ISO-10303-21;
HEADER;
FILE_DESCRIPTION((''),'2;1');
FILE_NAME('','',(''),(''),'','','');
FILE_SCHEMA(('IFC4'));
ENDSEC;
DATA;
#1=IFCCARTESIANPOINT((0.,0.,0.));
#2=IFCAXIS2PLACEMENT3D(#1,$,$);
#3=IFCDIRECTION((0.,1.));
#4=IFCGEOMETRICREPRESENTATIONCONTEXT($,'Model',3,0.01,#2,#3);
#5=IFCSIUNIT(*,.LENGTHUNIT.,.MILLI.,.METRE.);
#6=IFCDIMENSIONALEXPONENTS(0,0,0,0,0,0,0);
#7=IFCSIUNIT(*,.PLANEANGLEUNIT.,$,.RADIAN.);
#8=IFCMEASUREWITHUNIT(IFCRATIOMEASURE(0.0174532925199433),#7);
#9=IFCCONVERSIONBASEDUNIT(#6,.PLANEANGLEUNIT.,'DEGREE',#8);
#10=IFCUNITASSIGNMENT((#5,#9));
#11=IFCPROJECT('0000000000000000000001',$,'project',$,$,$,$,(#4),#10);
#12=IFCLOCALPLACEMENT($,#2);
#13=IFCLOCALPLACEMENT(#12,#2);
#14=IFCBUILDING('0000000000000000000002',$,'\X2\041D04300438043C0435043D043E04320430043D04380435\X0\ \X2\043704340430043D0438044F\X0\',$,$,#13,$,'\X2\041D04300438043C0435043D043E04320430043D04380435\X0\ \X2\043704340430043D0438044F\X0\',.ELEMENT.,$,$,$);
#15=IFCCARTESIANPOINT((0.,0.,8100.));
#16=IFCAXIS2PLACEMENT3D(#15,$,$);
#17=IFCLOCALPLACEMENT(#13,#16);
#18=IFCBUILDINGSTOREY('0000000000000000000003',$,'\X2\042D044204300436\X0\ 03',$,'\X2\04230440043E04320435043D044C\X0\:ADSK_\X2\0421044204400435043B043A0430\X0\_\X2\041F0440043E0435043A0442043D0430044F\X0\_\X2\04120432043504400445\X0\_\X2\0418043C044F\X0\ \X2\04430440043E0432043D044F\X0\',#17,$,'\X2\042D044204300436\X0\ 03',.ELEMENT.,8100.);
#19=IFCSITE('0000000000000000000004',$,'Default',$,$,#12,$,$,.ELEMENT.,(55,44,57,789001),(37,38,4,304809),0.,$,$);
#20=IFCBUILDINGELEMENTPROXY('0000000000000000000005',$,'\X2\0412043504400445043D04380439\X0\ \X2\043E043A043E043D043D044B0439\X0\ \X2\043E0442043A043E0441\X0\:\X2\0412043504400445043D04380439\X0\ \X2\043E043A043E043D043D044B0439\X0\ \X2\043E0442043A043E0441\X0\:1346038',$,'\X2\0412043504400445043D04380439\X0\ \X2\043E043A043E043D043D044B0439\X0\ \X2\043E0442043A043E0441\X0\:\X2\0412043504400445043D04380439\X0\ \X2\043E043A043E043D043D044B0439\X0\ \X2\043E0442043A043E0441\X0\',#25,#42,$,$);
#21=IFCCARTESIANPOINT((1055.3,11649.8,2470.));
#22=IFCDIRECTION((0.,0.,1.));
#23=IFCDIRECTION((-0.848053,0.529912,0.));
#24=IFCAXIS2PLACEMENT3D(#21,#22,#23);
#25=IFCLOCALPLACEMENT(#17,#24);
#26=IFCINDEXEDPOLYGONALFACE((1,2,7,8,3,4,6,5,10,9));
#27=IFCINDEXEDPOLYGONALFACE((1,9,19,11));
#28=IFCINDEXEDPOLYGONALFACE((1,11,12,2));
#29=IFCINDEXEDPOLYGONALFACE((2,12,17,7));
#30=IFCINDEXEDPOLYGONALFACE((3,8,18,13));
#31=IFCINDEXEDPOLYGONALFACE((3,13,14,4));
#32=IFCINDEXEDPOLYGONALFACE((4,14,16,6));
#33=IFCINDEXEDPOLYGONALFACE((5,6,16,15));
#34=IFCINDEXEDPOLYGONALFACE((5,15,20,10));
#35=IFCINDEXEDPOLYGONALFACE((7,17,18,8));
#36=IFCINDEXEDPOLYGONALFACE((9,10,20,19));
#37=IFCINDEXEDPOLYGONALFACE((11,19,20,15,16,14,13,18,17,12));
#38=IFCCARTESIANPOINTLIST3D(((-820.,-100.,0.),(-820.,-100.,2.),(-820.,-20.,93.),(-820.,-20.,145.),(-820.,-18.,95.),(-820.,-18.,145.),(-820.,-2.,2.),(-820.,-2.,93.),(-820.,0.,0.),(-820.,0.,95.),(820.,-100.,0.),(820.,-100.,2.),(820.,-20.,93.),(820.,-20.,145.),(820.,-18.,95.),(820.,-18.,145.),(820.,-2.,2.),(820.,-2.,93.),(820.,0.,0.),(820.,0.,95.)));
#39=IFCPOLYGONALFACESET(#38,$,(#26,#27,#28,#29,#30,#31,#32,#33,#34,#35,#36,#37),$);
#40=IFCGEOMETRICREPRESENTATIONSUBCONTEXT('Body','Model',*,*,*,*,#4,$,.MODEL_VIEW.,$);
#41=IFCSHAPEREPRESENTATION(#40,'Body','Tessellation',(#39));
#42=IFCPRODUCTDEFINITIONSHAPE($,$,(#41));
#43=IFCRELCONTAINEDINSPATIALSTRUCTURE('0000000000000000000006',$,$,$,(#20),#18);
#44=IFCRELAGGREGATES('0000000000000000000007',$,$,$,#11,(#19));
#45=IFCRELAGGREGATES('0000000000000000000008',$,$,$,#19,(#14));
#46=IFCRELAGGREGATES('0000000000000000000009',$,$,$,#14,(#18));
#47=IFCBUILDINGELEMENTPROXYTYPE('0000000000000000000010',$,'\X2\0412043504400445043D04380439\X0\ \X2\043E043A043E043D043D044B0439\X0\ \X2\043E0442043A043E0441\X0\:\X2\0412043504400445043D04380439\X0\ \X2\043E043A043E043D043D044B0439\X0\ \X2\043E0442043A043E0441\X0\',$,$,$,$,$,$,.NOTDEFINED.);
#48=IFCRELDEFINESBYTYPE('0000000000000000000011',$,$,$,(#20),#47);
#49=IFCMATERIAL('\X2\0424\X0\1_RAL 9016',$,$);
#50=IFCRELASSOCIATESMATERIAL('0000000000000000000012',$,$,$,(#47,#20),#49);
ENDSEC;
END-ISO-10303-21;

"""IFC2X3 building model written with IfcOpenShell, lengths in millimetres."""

from ifc_helpers import new_model, entity, si_unit, converted_unit, direction, frame, origin, place, context, subcontext, project, spatial, polyline, outline, extrude, source, transform, mapped, material, type_object, type_shapes, element, save


model = new_model("IFC2X3")

# Units and contexts
model_context = context("Model", 3, precision=0.01, world=origin(), true_north=direction((0.0, 1.0)))
body_context = subcontext(model_context, "Body", "Model", "MODEL_VIEW")
ifc_project = project(units=[si_unit("LENGTHUNIT", "METRE", prefix="MILLI"), converted_unit("PLANEANGLEUNIT", "DEGREE", entity("IfcRatioMeasure", 0.0174532925199433), si_unit("PLANEANGLEUNIT", "RADIAN"), dimensions=[0, 0, 0, 0, 0, 0, 0])], contexts=[model_context])

# Site, building, storey
site_placement = place(None, origin())
site = spatial("IfcSite", under=ifc_project, at=site_placement, Name="Default", CompositionType="ELEMENT", RefLatitude=(55, 44, 57, 789001), RefLongitude=(37, 38, 4, 304809), RefElevation=0.0)
building_placement = place(site_placement, origin())
building = spatial("IfcBuilding", under=site, at=building_placement, Name="Наименование здания", LongName="Наименование здания", CompositionType="ELEMENT")
storey_placement = place(building_placement, frame((0.0, 0.0, 8100.0)))
storey = spatial("IfcBuildingStorey", under=building, at=storey_placement, Name="Этаж 03", ObjectType="Уровень:ADSK_Стрелка_Проектная_Вверх_Имя уровня", LongName="Этаж 03", CompositionType="ELEMENT", Elevation=8100.0)

# Building element proxy
ifc_material_1 = material(Name="Ф1_RAL 9016")
building_element_proxy_type_1 = type_object("IfcBuildingElementProxyType", Name="Верхний оконный откос:Верхний оконный откос", PredefinedType="NOTDEFINED", material=ifc_material_1)
shared_shape_1 = source(origin(), body_context, "Body", "SweptSolid", [
    extrude(outline(polyline([(28.0, -10.0), (78.0, -10.0), (78.0, -8.0), (26.0, -8.0), (26.0, -26.0), (-65.0, -26.0), (-65.0, 72.0), (-67.0, 72.0), (-67.0, -28.0), (28.0, -28.0), (28.0, -10.0)])), frame((-820.0, -28.0, 67.0), z_axis=(1.0, 0.0, 0.0), x_axis=(0.0, 0.0, 1.0)), (0.0, 0.0, 1.0), 1640.0),
])
type_shapes(building_element_proxy_type_1, [shared_shape_1])
proxy_1_placement = place(storey_placement, frame((1055.3, 11649.8, 2470.0), z_axis=(0.0, 0.0, 1.0), x_axis=(-0.848053, 0.529912, 0.0)))
element("IfcBuildingElementProxy", 1, at=proxy_1_placement, inside=storey, type_object=building_element_proxy_type_1, material=ifc_material_1, Name="Верхний оконный откос:Верхний оконный откос:1346038", ObjectType="Верхний оконный откос:Верхний оконный откос", context=body_context, shape_type="MappedRepresentation", body=[
    mapped(shared_shape_1, transform((0.0, 0.0, 0.0), scale=1.0)),
])

save(model, "model.ifc")
